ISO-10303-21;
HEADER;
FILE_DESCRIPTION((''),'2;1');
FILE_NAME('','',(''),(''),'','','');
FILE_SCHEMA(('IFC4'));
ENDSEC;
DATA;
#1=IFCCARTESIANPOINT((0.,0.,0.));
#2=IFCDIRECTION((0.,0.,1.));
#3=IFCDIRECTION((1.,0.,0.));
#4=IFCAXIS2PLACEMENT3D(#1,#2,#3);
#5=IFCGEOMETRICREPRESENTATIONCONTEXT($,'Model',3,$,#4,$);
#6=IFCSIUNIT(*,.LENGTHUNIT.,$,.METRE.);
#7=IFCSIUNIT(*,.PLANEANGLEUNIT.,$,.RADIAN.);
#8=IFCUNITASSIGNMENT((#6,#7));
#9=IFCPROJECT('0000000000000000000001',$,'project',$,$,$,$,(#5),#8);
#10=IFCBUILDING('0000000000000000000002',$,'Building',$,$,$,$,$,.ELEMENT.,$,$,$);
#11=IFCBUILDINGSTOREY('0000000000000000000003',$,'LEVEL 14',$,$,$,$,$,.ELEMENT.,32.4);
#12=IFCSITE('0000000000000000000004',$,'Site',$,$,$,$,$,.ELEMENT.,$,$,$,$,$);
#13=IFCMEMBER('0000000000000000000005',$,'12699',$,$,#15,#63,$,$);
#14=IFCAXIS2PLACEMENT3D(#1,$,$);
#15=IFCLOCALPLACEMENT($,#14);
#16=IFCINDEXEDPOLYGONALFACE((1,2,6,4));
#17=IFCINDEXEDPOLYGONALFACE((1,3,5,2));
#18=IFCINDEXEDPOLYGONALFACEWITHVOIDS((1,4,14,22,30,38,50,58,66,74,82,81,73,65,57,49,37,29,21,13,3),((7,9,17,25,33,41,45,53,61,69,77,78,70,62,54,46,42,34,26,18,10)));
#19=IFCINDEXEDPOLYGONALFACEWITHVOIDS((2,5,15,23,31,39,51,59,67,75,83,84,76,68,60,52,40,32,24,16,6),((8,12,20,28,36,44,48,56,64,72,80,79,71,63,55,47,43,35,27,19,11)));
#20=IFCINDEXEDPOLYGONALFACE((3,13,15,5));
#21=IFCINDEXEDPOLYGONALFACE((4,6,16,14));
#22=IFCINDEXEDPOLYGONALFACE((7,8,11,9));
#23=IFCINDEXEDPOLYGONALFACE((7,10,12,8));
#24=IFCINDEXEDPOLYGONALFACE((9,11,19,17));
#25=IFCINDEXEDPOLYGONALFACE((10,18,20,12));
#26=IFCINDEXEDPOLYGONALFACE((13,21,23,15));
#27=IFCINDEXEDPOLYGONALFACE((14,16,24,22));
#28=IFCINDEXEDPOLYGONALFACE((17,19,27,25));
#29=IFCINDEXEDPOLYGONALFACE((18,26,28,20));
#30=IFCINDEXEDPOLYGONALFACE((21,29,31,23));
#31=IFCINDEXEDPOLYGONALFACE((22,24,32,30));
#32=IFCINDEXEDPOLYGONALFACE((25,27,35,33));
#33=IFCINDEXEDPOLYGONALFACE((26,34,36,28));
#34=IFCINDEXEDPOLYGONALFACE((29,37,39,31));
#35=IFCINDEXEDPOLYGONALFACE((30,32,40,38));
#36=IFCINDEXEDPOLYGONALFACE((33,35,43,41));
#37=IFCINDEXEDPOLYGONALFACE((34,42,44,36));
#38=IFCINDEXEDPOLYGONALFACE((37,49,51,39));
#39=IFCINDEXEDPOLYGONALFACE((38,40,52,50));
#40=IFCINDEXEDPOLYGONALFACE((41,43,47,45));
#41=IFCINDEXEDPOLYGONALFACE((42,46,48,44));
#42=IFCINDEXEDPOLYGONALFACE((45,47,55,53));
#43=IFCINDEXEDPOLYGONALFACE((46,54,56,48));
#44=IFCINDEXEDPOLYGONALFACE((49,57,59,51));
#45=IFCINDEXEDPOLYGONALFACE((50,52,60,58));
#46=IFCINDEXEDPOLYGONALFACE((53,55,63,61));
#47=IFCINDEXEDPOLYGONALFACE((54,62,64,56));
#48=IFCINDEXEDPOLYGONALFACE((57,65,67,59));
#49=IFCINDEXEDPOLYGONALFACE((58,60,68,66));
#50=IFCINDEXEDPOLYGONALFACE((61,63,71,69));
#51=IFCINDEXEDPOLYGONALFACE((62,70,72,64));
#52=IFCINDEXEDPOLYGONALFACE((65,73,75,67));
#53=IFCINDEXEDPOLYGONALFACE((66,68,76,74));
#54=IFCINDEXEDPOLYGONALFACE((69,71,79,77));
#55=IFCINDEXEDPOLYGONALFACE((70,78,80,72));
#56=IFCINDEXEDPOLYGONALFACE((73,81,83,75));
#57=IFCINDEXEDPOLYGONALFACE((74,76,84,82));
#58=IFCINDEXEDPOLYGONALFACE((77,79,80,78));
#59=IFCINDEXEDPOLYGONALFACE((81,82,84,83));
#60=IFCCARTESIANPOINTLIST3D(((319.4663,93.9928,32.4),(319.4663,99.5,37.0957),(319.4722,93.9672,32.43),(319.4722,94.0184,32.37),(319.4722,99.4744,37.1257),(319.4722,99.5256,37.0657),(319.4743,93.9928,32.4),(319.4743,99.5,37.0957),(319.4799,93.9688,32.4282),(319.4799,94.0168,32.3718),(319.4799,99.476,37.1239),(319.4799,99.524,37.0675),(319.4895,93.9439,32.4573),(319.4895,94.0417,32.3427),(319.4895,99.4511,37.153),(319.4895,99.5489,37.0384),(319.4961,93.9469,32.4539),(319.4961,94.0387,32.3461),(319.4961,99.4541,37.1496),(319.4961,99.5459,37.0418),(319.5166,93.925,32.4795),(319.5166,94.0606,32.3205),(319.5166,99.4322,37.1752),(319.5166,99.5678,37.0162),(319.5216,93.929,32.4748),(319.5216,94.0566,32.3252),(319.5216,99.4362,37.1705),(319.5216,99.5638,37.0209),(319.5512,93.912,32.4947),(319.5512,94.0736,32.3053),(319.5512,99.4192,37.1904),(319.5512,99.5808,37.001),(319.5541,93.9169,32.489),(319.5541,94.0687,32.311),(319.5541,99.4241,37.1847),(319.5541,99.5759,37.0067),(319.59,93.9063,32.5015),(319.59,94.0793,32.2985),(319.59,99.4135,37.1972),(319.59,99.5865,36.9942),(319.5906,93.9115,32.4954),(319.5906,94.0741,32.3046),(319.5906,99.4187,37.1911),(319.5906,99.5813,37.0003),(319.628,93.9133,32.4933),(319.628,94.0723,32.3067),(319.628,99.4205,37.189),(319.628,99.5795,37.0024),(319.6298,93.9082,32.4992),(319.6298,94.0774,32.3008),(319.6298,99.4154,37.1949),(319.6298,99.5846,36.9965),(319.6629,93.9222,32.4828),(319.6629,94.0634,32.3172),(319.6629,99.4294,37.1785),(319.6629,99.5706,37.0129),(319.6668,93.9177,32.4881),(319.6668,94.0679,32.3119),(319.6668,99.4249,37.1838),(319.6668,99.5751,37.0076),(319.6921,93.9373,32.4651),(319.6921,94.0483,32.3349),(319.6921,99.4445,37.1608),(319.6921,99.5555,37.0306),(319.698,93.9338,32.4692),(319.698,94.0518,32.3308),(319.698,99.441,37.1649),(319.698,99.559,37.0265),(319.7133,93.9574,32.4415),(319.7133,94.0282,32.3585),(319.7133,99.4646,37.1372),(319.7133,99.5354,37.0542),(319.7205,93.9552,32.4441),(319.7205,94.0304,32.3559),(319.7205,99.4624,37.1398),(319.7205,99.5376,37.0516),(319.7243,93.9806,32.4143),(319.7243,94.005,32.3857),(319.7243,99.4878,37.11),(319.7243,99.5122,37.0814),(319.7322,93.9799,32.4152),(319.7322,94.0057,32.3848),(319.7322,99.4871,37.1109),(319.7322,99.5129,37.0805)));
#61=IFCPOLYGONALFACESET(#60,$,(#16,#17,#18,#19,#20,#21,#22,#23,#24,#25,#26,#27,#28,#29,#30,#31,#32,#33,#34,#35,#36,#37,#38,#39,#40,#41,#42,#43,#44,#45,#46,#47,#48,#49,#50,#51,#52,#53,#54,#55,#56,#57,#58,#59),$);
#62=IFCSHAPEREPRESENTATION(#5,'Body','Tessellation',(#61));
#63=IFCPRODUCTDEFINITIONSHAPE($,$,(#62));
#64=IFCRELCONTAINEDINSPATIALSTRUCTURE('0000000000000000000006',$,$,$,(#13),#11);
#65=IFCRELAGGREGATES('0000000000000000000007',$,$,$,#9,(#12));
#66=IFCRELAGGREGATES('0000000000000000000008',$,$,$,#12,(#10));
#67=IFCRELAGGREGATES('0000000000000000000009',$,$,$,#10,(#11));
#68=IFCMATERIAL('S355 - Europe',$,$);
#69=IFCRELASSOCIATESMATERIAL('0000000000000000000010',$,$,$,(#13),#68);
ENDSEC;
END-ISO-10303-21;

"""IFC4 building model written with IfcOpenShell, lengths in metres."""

from ifc_helpers import new_model, si_unit, frame, origin_with_axes, origin_2d_with_axis, place, context, project, spatial, hollow_circle, extrude, material, material_profile, profile_set, profile_usage, element, save


model = new_model("IFC4")

# Units and contexts
model_context = context("Model", 3, world=origin_with_axes())
ifc_project = project(units=[si_unit("LENGTHUNIT", "METRE"), si_unit("PLANEANGLEUNIT", "RADIAN")], contexts=[model_context])

# Site, building, storey
site = spatial("IfcSite", under=ifc_project, Name="Site", CompositionType="ELEMENT")
building = spatial("IfcBuilding", under=site, Name="Building", CompositionType="ELEMENT")
storey = spatial("IfcBuildingStorey", under=building, Name="LEVEL 14", CompositionType="ELEMENT", Elevation=32.4)

# Shared definitions
ifc_material = material(Name="S355 - Europe")

# Member
ifc_material_profile_1 = material_profile(ifc_material, hollow_circle(Radius=0.1337, WallThickness=0.008, at=origin_2d_with_axis()))
ifc_profile_set_1 = profile_set([ifc_material_profile_1])
ifc_profile_usage_1 = profile_usage(ifc_profile_set_1, cardinal=10)
member_1_placement = place(None, frame((319.6, 93.9928, 32.4), z_axis=(0.0, 0.760944, 0.648817), x_axis=(-1.0, 0.0, 0.0)))
element("IfcMember", 1, at=member_1_placement, inside=storey, material=ifc_profile_usage_1, Name="12699", context=model_context, shape_type="SweptSolid", body=[
    extrude(hollow_circle(Radius=0.1337, WallThickness=0.008, at=origin_2d_with_axis()), origin_with_axes(), (0.0, 0.0, 1.0), 7.2373),
])

save(model, "model.ifc")
